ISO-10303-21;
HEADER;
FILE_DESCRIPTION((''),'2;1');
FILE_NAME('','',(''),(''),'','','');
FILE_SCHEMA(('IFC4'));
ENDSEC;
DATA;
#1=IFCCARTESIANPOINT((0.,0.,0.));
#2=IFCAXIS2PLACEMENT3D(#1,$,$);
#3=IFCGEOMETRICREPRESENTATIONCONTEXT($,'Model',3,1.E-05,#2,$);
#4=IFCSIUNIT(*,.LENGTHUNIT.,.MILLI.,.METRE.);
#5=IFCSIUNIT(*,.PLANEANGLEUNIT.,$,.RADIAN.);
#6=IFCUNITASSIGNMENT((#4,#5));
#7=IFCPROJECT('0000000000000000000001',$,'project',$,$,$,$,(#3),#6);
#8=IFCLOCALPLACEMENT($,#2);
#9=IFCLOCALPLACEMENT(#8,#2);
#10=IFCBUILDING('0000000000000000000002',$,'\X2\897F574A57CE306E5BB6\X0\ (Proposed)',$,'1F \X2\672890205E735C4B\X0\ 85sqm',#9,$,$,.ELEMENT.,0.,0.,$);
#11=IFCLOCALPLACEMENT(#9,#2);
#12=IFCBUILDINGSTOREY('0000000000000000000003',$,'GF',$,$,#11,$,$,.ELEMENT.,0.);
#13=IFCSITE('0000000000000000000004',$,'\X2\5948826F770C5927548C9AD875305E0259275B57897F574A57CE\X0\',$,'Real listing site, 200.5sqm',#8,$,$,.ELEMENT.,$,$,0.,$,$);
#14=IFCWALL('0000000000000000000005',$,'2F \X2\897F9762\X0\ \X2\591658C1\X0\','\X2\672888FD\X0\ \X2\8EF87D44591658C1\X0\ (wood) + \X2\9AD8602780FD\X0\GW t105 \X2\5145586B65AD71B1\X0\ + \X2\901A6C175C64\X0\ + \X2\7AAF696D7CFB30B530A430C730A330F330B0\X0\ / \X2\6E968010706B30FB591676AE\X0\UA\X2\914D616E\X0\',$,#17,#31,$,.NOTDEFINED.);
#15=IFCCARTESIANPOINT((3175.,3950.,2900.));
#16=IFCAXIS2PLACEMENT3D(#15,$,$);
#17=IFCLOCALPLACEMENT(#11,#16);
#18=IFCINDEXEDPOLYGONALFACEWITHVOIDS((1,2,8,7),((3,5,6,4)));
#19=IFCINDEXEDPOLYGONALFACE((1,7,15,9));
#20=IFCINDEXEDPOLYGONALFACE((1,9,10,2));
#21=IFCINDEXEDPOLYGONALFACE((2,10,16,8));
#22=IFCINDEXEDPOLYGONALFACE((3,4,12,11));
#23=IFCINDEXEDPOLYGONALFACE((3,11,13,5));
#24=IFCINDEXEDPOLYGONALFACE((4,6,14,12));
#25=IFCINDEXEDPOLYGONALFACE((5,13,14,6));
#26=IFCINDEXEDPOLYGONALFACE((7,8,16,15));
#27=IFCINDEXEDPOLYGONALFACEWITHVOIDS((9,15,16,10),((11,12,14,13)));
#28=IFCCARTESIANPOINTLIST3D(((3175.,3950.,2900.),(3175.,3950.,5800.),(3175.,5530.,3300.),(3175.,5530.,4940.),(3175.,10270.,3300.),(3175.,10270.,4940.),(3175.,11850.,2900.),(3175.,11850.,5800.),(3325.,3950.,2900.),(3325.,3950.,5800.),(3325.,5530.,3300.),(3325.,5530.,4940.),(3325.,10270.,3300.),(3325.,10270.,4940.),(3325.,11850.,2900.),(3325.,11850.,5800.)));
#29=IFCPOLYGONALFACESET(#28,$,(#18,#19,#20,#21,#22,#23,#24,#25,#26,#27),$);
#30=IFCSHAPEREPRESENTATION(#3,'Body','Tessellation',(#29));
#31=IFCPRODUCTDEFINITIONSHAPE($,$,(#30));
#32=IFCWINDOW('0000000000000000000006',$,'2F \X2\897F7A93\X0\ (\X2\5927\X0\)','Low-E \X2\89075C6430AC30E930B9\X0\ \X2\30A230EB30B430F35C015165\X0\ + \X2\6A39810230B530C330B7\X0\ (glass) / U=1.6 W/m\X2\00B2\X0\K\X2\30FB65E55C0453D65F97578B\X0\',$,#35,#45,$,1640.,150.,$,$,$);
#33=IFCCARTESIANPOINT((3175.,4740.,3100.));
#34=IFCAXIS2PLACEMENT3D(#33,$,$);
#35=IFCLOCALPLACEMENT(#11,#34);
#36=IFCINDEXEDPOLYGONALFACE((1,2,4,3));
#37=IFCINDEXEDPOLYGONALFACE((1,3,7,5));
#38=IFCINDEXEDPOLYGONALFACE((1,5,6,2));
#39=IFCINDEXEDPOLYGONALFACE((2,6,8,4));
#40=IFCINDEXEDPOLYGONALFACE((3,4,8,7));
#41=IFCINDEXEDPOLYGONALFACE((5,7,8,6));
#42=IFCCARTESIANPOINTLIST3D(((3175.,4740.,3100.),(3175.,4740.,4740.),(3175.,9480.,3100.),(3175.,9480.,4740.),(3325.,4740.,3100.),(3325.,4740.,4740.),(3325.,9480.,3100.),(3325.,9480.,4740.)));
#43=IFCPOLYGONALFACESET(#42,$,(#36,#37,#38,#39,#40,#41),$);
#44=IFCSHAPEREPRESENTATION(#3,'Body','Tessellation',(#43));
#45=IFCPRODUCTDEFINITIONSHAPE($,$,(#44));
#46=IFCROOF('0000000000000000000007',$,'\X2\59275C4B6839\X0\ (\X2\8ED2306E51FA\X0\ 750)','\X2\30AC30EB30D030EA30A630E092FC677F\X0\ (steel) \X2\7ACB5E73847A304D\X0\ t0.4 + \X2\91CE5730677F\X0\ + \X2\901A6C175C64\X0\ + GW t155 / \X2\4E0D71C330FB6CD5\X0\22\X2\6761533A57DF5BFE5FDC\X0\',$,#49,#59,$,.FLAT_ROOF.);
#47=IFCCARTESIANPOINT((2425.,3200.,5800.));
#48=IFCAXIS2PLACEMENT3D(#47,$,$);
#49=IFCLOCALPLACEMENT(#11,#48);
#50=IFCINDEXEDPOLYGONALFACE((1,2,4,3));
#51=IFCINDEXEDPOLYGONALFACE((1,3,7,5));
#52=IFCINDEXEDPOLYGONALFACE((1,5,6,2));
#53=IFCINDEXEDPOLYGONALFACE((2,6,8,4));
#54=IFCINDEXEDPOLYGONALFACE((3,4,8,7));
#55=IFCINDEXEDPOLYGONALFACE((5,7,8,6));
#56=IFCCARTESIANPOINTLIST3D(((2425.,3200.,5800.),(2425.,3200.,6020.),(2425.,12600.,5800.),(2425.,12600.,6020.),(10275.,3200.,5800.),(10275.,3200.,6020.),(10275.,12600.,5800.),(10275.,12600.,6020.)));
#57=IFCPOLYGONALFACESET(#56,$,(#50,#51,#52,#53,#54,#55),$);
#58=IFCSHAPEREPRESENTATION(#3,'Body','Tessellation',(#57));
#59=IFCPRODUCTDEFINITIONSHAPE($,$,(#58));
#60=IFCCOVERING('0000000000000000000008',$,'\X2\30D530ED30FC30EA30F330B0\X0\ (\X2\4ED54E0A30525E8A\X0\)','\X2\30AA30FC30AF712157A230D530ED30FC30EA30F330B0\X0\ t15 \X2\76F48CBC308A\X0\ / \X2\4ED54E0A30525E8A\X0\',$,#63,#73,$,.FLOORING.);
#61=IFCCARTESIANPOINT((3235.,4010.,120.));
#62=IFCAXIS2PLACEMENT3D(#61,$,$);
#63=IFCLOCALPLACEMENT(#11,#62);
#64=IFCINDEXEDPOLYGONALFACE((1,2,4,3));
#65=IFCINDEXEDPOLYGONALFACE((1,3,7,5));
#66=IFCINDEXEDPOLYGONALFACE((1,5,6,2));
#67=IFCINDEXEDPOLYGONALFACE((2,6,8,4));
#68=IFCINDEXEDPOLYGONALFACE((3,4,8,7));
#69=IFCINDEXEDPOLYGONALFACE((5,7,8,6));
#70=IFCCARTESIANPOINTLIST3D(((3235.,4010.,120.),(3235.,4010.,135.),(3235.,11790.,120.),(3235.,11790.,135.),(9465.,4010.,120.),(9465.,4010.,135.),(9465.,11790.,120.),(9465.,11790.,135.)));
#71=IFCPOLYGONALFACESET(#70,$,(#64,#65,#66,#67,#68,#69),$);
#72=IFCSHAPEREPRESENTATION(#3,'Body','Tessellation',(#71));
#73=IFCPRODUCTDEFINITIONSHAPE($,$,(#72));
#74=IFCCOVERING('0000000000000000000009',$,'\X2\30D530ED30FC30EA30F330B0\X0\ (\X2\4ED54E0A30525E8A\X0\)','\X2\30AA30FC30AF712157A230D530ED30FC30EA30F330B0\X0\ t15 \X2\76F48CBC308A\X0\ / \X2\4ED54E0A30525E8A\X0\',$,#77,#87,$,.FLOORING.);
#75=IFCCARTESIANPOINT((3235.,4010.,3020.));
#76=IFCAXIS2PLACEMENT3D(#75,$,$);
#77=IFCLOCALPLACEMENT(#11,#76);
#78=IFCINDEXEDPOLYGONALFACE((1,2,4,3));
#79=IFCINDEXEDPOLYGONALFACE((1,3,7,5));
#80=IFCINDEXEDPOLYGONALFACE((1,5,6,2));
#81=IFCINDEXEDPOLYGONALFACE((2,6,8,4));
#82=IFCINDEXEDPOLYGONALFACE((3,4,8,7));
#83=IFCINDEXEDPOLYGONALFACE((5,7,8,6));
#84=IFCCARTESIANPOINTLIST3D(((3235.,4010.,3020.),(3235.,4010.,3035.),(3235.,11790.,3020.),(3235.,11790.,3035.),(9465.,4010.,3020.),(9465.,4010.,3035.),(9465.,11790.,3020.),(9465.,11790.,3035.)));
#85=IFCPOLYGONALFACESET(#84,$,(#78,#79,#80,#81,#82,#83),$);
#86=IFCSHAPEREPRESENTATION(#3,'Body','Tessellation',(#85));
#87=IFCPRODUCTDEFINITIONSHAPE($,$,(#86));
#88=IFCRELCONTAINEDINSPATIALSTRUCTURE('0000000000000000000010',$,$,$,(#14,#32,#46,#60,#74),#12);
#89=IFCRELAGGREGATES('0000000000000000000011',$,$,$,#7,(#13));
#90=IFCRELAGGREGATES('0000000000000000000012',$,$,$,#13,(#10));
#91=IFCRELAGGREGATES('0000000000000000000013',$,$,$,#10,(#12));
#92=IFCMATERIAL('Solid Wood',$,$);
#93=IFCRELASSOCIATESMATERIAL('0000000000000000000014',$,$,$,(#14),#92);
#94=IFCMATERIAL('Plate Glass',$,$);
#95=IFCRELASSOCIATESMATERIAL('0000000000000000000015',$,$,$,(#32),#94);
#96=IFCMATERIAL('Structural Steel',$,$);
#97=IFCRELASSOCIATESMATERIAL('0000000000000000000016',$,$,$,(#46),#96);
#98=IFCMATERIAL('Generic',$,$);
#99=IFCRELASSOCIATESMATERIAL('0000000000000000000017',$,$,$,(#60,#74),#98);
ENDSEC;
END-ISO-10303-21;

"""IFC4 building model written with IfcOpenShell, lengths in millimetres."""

from ifc_helpers import new_model, si_unit, frame, frame_2d, origin, place, context, project, spatial, rectangle, extrude, material, element, fill, save


model = new_model("IFC4")

# Units and contexts
model_context = context("Model", 3, precision=1e-05, world=origin())
ifc_project = project(units=[si_unit("LENGTHUNIT", "METRE", prefix="MILLI"), si_unit("PLANEANGLEUNIT", "RADIAN")], contexts=[model_context])

# Site, building, storey
site_placement = place(None, origin())
site = spatial("IfcSite", under=ifc_project, at=site_placement, Name="奈良県大和高田市大字西坊城", ObjectType="Real listing site, 200.5sqm", CompositionType="ELEMENT", RefElevation=0.0)
building_placement = place(site_placement, origin())
building = spatial("IfcBuilding", under=site, at=building_placement, Name="西坊城の家 (Proposed)", ObjectType="1F 木造平屋 85sqm", CompositionType="ELEMENT", ElevationOfRefHeight=0.0, ElevationOfTerrain=0.0)
storey_placement = place(building_placement, origin())
storey = spatial("IfcBuildingStorey", under=building, at=storey_placement, Name="GF", CompositionType="ELEMENT", Elevation=0.0)

# Shared definitions
ifc_material_1 = material(Name="Solid Wood")
ifc_material_2 = material(Name="Generic")

# Shared definitions
ifc_material_3 = material(Name="Plate Glass")

# Wall, opening, window
wall_1_placement = place(storey_placement, frame((3175.0, 3950.0, 2900.0)))
wall_1 = element("IfcWall", 1, at=wall_1_placement, inside=storey, material=ifc_material_1, Name="2F 西面 外壁", Description="木製 軸組外壁 (wood) + 高性能GW t105 充填断熱 + 通気層 + 窯業系サイディング / 準耐火・外皮UA配慮", PredefinedType="NOTDEFINED", context=model_context, shape_type="SweptSolid", body=[
    extrude(rectangle(XDim=150.0, YDim=7900.0, at=frame_2d((75.0, 3950.0))), frame((3175.0, 3950.0, 2900.0)), (0.0, 0.0, 1.0), 2900.0),
])
opening_1_placement = place(storey_placement, frame((3175.0, 4740.0, 3100.0)))
opening_1 = element("IfcOpeningElement", 2, at=opening_1_placement, cuts=wall_1, PredefinedType="NOTDEFINED", context=model_context, shape_type="SweptSolid", body=[
    extrude(rectangle(XDim=150.0, YDim=4740.0, at=frame_2d((75.0, 2370.0))), frame((3175.0, 4740.0, 3100.0)), (0.0, 0.0, 1.0), 1640.0),
])
window_1_placement = place(storey_placement, frame((3175.0, 4740.0, 3100.0)))
window_1 = element("IfcWindow", 3, at=window_1_placement, inside=storey, material=ifc_material_3, Name="2F 西窓 (大)", Description="Low-E 複層ガラス アルゴン封入 + 樹脂サッシ (glass) / U=1.6 W/m²K・日射取得型", OverallHeight=1640.0, OverallWidth=150.0, context=model_context, shape_type="SweptSolid", body=[
    extrude(rectangle(XDim=150.0, YDim=4740.0, at=frame_2d((75.0, 2370.0))), frame((3175.0, 4740.0, 3100.0)), (0.0, 0.0, 1.0), 1640.0),
])
fill(opening_1, window_1)

# Roof
ifc_material_4 = material(Name="Structural Steel")
roof_placement = place(storey_placement, frame((2425.0, 3200.0, 5800.0)))
element("IfcRoof", 4, at=roof_placement, inside=storey, material=ifc_material_4, Name="大屋根 (軒の出 750)", Description="ガルバリウム鋼板 (steel) 立平葺き t0.4 + 野地板 + 通気層 + GW t155 / 不燃・法22条区域対応", PredefinedType="FLAT_ROOF", context=model_context, shape_type="SweptSolid", body=[
    extrude(rectangle(XDim=7850.0, YDim=9400.0, at=frame_2d((3925.0, 4700.0))), frame((2425.0, 3200.0, 5800.0)), (0.0, 0.0, 1.0), 220.0),
])

# Coverings
covering_1_placement = place(storey_placement, frame((3235.0, 4010.0, 120.0)))
element("IfcCovering", 5, at=covering_1_placement, inside=storey, material=ifc_material_2, Name="フローリング (仕上げ床)", Description="オーク無垢フローリング t15 直貼り / 仕上げ床", PredefinedType="FLOORING", context=model_context, shape_type="SweptSolid", body=[
    extrude(rectangle(XDim=6230.0, YDim=7780.0, at=frame_2d((3115.0, 3890.0))), frame((3235.0, 4010.0, 120.0)), (0.0, 0.0, 1.0), 15.0),
])
covering_2_placement = place(storey_placement, frame((3235.0, 4010.0, 3020.0)))
element("IfcCovering", 6, at=covering_2_placement, inside=storey, material=ifc_material_2, Name="フローリング (仕上げ床)", Description="オーク無垢フローリング t15 直貼り / 仕上げ床", PredefinedType="FLOORING", context=model_context, shape_type="SweptSolid", body=[
    extrude(rectangle(XDim=6230.0, YDim=7780.0, at=frame_2d((3115.0, 3890.0))), frame((3235.0, 4010.0, 3020.0)), (0.0, 0.0, 1.0), 15.0),
])

save(model, "model.ifc")
